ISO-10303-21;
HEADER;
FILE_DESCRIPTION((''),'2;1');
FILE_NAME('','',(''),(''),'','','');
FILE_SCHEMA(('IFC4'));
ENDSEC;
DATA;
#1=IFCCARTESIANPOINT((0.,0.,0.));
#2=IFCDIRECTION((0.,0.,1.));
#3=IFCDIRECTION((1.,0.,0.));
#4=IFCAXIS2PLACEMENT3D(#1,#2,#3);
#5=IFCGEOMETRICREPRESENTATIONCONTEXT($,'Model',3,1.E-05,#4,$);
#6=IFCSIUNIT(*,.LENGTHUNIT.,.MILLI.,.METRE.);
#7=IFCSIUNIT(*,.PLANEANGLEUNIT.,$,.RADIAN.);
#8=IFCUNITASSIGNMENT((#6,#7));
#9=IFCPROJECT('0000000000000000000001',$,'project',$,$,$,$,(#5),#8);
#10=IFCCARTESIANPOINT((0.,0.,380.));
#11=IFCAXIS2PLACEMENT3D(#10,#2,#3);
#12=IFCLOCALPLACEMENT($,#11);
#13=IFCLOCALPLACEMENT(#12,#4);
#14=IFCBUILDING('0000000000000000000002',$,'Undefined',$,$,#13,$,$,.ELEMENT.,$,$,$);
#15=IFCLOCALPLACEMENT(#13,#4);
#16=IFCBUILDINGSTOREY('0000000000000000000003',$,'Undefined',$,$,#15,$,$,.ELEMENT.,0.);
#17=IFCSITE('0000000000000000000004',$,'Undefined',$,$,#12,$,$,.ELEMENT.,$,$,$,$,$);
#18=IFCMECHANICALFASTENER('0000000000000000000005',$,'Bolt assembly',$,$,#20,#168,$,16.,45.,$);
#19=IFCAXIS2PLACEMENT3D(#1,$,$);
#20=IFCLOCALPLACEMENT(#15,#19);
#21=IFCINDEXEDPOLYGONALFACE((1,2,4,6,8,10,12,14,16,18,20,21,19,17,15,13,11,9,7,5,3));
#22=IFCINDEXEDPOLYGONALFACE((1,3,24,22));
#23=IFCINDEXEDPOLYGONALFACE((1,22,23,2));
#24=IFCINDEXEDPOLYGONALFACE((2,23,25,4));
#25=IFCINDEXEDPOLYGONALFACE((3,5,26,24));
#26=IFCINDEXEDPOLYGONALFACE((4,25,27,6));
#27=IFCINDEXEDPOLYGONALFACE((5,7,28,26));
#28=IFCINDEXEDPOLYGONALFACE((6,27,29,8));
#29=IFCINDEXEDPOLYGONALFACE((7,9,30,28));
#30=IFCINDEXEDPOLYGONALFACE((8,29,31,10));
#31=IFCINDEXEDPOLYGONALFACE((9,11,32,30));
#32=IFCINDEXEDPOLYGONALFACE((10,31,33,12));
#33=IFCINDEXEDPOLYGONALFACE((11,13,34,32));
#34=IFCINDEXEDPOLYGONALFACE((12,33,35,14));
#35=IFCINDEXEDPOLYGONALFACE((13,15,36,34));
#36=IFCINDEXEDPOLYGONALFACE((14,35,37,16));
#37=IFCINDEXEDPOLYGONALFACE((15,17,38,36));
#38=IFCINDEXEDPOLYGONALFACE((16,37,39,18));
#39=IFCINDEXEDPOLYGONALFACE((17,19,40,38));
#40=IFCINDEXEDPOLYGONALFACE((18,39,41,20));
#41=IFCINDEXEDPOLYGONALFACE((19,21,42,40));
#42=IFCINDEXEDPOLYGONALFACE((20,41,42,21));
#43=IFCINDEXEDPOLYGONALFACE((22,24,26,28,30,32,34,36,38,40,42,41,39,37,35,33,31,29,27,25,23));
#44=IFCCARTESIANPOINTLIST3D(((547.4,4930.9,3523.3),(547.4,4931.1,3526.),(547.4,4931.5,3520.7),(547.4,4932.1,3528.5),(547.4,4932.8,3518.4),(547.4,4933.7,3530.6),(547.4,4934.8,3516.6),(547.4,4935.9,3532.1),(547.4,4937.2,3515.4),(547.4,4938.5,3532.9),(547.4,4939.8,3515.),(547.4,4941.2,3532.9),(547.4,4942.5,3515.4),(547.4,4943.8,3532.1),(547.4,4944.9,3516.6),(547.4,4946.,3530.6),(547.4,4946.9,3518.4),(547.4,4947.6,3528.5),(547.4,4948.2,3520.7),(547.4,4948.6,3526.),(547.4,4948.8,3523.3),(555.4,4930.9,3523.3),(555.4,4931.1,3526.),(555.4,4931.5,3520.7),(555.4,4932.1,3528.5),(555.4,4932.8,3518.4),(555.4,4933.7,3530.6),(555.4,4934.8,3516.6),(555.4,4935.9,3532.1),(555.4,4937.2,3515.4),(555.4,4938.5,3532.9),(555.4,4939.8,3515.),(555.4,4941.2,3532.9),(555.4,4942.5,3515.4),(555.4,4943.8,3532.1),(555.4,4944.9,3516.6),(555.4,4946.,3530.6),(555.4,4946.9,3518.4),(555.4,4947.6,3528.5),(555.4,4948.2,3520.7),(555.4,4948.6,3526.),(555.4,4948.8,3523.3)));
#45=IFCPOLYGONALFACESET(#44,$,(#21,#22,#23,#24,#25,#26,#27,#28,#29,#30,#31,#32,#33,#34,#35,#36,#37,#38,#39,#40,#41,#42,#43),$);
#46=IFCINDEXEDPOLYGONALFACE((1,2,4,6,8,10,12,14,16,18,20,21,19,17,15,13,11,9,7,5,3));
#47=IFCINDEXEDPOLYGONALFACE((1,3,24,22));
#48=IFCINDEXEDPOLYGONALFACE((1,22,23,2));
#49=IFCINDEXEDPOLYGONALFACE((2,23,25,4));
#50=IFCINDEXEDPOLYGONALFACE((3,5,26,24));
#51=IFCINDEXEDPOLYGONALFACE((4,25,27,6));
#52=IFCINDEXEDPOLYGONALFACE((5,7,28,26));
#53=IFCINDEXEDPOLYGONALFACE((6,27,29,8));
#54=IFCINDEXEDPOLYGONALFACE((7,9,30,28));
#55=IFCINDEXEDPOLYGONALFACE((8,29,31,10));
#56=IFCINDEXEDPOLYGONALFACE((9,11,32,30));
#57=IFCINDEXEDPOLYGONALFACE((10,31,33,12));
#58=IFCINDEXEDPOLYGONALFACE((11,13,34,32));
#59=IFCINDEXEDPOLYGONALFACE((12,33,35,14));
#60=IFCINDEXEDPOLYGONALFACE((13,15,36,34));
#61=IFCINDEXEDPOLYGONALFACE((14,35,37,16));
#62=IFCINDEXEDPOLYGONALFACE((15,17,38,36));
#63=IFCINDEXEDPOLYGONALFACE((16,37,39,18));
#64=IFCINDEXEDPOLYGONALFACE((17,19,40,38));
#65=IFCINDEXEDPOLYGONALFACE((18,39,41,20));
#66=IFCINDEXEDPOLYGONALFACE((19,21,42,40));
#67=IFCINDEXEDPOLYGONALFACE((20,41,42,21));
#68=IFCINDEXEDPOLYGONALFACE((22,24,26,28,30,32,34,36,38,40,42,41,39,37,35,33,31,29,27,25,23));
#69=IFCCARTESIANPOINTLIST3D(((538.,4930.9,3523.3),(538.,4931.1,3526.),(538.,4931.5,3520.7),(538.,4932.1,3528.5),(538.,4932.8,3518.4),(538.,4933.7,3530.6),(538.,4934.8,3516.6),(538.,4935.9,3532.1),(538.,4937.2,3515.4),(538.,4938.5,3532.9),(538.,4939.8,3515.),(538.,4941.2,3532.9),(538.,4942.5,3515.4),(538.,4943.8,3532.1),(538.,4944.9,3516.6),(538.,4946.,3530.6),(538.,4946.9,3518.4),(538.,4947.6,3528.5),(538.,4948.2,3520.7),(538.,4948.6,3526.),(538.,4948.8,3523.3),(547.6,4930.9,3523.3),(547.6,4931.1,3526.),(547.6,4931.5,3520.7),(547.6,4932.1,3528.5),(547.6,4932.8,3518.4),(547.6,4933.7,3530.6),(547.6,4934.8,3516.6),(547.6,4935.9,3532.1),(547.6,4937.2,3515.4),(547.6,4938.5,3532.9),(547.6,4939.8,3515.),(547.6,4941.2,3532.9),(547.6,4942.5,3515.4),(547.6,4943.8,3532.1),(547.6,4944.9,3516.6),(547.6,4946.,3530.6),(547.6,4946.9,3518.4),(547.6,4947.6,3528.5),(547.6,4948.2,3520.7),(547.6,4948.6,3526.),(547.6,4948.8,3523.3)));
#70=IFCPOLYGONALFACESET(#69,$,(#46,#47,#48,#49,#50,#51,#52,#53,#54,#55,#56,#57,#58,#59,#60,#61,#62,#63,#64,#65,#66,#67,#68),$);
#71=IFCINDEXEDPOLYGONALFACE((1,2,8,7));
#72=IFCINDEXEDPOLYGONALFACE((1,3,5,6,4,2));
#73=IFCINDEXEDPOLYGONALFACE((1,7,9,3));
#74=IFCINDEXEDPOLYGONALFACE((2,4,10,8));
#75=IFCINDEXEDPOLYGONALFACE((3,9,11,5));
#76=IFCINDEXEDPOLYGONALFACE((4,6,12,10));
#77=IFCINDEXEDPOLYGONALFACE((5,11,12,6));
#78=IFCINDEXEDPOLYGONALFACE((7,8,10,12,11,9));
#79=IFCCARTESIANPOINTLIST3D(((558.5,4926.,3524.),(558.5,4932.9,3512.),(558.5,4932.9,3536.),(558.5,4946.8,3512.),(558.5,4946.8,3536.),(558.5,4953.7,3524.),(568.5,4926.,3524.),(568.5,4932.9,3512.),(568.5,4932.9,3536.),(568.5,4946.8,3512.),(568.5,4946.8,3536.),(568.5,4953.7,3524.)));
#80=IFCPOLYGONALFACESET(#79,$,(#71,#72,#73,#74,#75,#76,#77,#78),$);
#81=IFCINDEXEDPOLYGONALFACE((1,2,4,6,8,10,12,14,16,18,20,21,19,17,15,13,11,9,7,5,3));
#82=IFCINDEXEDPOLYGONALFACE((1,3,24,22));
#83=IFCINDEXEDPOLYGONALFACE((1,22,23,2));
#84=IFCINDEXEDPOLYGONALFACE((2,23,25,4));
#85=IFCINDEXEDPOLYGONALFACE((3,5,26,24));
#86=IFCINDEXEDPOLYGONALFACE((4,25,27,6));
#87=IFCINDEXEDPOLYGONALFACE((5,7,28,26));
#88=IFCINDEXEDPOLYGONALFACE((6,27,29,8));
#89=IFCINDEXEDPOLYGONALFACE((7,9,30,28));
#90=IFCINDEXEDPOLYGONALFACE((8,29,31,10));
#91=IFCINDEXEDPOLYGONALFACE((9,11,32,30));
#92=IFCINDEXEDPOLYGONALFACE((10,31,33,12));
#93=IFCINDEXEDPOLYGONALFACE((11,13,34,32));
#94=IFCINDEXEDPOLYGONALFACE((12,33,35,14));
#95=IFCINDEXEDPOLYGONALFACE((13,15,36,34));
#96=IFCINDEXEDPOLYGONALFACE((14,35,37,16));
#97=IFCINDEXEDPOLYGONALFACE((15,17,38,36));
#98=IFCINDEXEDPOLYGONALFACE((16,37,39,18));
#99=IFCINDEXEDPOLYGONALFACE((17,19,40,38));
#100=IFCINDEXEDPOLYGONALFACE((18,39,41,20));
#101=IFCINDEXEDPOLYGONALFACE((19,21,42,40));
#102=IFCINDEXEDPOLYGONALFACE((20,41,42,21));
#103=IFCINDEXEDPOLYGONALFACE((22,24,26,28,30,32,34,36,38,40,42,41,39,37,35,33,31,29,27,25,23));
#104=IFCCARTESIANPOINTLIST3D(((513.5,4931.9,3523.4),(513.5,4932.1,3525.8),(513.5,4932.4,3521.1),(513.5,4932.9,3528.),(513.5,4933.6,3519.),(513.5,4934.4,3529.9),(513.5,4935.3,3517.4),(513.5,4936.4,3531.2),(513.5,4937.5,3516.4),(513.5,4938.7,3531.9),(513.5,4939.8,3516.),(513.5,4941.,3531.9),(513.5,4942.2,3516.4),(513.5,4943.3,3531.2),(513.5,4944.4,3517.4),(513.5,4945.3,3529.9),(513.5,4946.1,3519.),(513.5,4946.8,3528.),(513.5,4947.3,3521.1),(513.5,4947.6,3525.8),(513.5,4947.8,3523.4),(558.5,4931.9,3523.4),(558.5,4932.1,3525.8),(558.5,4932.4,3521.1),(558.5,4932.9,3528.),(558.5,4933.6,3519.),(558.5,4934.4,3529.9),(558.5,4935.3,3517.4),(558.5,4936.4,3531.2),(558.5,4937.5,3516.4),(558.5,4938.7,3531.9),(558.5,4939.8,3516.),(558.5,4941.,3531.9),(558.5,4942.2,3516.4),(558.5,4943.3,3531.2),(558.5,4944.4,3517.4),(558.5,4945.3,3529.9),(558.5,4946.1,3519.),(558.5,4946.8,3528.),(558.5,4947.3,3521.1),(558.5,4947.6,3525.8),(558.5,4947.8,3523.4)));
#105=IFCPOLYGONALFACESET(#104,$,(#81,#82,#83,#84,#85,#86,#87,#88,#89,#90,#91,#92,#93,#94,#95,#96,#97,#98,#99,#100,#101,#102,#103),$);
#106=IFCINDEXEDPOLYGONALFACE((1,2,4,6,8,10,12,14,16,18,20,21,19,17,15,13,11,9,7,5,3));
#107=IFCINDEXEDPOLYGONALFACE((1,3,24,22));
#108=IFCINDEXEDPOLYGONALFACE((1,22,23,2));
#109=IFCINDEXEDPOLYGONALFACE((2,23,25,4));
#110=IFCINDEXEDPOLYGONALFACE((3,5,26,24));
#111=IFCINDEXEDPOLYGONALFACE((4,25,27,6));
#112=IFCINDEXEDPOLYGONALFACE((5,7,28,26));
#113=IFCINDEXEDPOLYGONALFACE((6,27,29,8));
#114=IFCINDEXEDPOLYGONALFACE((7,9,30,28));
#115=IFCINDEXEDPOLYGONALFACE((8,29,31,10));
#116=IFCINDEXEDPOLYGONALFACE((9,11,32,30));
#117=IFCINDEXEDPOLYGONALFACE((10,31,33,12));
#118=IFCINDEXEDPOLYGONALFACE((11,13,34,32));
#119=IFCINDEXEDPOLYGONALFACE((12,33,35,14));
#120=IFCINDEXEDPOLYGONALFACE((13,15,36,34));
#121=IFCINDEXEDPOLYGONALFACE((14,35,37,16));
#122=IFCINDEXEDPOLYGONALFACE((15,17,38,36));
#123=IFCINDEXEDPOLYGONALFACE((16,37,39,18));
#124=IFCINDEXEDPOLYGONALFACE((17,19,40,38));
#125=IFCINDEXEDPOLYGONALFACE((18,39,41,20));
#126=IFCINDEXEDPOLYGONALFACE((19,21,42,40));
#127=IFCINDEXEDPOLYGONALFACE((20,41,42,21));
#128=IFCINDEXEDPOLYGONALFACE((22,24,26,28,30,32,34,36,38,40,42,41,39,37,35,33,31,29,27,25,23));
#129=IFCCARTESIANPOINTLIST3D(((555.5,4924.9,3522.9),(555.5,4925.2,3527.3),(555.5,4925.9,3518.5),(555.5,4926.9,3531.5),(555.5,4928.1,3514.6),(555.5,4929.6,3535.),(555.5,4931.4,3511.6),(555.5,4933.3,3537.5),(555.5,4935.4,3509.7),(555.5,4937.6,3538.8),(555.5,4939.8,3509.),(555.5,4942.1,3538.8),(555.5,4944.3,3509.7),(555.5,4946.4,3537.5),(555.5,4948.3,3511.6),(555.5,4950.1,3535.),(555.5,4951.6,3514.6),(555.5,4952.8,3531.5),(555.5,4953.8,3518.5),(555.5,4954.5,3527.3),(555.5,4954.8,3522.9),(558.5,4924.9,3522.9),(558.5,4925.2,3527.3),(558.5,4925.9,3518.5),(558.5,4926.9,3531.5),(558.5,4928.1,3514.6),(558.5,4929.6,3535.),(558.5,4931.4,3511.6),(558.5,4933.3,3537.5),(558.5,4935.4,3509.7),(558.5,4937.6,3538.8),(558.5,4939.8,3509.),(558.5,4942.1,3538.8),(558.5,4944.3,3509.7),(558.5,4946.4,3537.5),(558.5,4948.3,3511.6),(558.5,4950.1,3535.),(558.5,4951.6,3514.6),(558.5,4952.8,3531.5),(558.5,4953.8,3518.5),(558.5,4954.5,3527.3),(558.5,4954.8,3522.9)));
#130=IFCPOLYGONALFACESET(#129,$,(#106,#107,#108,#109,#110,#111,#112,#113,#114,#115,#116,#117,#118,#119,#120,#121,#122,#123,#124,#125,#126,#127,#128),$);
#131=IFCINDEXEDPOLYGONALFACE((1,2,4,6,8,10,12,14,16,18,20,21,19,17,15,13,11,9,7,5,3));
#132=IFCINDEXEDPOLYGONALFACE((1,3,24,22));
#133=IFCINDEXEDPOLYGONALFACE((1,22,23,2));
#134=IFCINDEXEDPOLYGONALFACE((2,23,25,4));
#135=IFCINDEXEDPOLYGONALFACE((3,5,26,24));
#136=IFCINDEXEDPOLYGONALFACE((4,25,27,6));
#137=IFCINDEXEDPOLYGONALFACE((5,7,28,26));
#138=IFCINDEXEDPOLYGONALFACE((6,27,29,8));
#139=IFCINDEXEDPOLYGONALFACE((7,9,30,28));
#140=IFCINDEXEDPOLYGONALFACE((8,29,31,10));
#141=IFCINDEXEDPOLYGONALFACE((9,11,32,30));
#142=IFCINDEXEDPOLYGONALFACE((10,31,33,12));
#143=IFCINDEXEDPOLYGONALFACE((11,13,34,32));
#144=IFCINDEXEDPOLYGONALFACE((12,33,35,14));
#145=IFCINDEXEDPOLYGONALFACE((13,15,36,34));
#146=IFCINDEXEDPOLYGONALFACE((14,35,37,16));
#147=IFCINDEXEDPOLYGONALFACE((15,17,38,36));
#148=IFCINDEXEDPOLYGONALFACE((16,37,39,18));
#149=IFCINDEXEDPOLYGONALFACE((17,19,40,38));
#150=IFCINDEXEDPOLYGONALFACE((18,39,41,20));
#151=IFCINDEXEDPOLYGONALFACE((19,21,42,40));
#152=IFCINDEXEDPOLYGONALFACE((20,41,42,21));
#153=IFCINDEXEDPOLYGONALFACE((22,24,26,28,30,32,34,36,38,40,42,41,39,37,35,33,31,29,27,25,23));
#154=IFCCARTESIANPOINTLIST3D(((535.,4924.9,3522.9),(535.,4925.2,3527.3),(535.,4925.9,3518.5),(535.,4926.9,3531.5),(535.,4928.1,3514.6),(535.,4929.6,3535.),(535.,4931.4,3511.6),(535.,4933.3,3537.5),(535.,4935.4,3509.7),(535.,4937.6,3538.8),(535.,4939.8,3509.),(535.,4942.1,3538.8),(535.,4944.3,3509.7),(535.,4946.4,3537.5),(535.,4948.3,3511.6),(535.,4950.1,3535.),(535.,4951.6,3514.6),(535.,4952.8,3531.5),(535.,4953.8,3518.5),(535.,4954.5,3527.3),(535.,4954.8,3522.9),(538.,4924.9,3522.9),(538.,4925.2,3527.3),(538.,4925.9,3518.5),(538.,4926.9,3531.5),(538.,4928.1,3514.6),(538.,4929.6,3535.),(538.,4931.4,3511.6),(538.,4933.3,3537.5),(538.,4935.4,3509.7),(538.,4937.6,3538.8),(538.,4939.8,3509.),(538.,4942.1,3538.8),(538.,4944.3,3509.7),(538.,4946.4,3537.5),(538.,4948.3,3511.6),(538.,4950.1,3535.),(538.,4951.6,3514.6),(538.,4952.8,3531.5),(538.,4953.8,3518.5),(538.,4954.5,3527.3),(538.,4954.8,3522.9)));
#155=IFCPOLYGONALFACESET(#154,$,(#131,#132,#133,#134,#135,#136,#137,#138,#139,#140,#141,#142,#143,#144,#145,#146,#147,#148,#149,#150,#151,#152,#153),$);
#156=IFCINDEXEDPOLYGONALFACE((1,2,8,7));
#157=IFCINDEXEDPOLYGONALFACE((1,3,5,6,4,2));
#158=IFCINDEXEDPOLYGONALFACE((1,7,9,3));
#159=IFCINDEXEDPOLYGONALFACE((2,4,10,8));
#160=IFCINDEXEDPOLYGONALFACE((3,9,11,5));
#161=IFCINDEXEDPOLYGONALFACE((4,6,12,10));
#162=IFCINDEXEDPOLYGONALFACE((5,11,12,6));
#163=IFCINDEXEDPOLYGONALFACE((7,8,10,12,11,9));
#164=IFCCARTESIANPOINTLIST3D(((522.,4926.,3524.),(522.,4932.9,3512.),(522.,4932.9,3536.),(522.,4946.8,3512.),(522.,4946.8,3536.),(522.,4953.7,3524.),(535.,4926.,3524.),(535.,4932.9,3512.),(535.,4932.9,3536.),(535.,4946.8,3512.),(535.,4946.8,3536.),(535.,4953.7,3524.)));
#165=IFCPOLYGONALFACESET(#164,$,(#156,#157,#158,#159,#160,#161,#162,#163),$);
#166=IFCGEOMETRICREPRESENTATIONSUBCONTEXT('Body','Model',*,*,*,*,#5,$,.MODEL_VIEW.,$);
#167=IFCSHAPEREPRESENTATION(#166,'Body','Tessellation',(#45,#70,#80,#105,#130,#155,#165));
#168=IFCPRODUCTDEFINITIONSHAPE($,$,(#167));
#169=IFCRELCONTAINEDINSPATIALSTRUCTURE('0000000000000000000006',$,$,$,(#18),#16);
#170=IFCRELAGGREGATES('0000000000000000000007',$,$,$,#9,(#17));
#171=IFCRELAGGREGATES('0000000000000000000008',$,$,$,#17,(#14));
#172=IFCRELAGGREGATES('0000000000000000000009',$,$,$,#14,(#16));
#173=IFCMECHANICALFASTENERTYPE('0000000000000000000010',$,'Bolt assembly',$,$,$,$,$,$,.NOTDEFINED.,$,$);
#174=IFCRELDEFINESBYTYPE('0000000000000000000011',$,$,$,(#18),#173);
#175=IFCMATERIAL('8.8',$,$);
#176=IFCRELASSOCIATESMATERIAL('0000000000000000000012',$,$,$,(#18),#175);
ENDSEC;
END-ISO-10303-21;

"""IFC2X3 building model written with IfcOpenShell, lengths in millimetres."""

from ifc_helpers import new_model, si_unit, frame, origin_with_axes, origin_2d_with_axis, place, context, subcontext, project, spatial, polyline, circle, outline, extrude, source, transform, mapped, material, type_object, element, save


model = new_model("IFC2X3")

# Units and contexts
model_context = context("Model", 3, precision=1e-05, world=origin_with_axes())
body_context = subcontext(model_context, "Body", "Model", "MODEL_VIEW")
ifc_project = project(units=[si_unit("LENGTHUNIT", "METRE", prefix="MILLI"), si_unit("PLANEANGLEUNIT", "RADIAN")], contexts=[model_context])

# Site, building, storey
site_placement = place(None, frame((0.0, 0.0, 380.0), z_axis=(0.0, 0.0, 1.0), x_axis=(1.0, 0.0, 0.0)))
site = spatial("IfcSite", under=ifc_project, at=site_placement, Name="Undefined", CompositionType="ELEMENT")
building_placement = place(site_placement, origin_with_axes())
building = spatial("IfcBuilding", under=site, at=building_placement, Name="Undefined", CompositionType="ELEMENT")
storey_placement = place(building_placement, origin_with_axes())
storey = spatial("IfcBuildingStorey", under=building, at=storey_placement, Name="Undefined", CompositionType="ELEMENT", Elevation=0.0)

# Mechanical fastener
ifc_material_1 = material(Name="8.8")
mechanical_fastener_type = type_object("IfcMechanicalFastenerType", Name="Bolt assembly")
shared_shape_1 = source(origin_with_axes(), body_context, "Body", "SweptSolid", [
    extrude(circle(Radius=9.0, at=origin_2d_with_axis()), frame((0.0, -7.9, 0.0), z_axis=(0.0, 1.0, 0.0), x_axis=(1.0, 0.0, 0.0)), (0.0, 0.0, 1.0), 8.0),
    extrude(circle(Radius=9.0, at=origin_2d_with_axis()), frame((0.0, -0.1, 0.0), z_axis=(0.0, 1.0, 0.0), x_axis=(1.0, 0.0, 0.0)), (0.0, 0.0, 1.0), 9.6),
    extrude(outline(polyline([(12.0, -6.9), (12.0, 6.9), (0.0, 13.9), (-12.0, 6.9), (-12.0, -6.9), (0.0, -13.9), (12.0, -6.9)])), frame((0.0, -21.0, 0.0), z_axis=(0.0, 1.0, 0.0), x_axis=(1.0, 0.0, 0.0)), (0.0, 0.0, 1.0), 10.0),
    extrude(circle(Radius=8.0, at=origin_2d_with_axis()), frame((0.0, -11.0, 0.0), z_axis=(0.0, 1.0, 0.0), x_axis=(1.0, 0.0, 0.0)), (0.0, 0.0, 1.0), 45.0),
    extrude(circle(Radius=15.0, at=origin_2d_with_axis()), frame((0.0, -11.0, 0.0), z_axis=(0.0, 1.0, 0.0), x_axis=(1.0, 0.0, 0.0)), (0.0, 0.0, 1.0), 3.0),
    extrude(circle(Radius=15.0, at=origin_2d_with_axis()), frame((0.0, 9.5, 0.0), z_axis=(0.0, 1.0, 0.0), x_axis=(1.0, 0.0, 0.0)), (0.0, 0.0, 1.0), 3.0),
    extrude(outline(polyline([(12.0, -6.9), (12.0, 6.9), (0.0, 13.9), (-12.0, 6.9), (-12.0, -6.9), (0.0, -13.9), (12.0, -6.9)])), frame((0.0, 12.5, 0.0), z_axis=(0.0, 1.0, 0.0), x_axis=(1.0, 0.0, 0.0)), (0.0, 0.0, 1.0), 13.0),
])
for number, where, z_axis, x_axis, name in (
    (1, (547.5, 4902.3, 3594.0), (0.0, 1.0, 0.0), (0.0, 0.0, -1.0), "Bolt assembly"),
):
    element("IfcMechanicalFastener", number, at=place(storey_placement, frame(where, z_axis=z_axis, x_axis=x_axis)), inside=storey, type_object=mechanical_fastener_type, material=ifc_material_1, Name=name, NominalDiameter=16.0, NominalLength=45.0, context=body_context, shape_type="MappedRepresentation", body=[
        mapped(shared_shape_1, transform((70.0, 0.0, 37.5))),
    ])

save(model, "model.ifc")
